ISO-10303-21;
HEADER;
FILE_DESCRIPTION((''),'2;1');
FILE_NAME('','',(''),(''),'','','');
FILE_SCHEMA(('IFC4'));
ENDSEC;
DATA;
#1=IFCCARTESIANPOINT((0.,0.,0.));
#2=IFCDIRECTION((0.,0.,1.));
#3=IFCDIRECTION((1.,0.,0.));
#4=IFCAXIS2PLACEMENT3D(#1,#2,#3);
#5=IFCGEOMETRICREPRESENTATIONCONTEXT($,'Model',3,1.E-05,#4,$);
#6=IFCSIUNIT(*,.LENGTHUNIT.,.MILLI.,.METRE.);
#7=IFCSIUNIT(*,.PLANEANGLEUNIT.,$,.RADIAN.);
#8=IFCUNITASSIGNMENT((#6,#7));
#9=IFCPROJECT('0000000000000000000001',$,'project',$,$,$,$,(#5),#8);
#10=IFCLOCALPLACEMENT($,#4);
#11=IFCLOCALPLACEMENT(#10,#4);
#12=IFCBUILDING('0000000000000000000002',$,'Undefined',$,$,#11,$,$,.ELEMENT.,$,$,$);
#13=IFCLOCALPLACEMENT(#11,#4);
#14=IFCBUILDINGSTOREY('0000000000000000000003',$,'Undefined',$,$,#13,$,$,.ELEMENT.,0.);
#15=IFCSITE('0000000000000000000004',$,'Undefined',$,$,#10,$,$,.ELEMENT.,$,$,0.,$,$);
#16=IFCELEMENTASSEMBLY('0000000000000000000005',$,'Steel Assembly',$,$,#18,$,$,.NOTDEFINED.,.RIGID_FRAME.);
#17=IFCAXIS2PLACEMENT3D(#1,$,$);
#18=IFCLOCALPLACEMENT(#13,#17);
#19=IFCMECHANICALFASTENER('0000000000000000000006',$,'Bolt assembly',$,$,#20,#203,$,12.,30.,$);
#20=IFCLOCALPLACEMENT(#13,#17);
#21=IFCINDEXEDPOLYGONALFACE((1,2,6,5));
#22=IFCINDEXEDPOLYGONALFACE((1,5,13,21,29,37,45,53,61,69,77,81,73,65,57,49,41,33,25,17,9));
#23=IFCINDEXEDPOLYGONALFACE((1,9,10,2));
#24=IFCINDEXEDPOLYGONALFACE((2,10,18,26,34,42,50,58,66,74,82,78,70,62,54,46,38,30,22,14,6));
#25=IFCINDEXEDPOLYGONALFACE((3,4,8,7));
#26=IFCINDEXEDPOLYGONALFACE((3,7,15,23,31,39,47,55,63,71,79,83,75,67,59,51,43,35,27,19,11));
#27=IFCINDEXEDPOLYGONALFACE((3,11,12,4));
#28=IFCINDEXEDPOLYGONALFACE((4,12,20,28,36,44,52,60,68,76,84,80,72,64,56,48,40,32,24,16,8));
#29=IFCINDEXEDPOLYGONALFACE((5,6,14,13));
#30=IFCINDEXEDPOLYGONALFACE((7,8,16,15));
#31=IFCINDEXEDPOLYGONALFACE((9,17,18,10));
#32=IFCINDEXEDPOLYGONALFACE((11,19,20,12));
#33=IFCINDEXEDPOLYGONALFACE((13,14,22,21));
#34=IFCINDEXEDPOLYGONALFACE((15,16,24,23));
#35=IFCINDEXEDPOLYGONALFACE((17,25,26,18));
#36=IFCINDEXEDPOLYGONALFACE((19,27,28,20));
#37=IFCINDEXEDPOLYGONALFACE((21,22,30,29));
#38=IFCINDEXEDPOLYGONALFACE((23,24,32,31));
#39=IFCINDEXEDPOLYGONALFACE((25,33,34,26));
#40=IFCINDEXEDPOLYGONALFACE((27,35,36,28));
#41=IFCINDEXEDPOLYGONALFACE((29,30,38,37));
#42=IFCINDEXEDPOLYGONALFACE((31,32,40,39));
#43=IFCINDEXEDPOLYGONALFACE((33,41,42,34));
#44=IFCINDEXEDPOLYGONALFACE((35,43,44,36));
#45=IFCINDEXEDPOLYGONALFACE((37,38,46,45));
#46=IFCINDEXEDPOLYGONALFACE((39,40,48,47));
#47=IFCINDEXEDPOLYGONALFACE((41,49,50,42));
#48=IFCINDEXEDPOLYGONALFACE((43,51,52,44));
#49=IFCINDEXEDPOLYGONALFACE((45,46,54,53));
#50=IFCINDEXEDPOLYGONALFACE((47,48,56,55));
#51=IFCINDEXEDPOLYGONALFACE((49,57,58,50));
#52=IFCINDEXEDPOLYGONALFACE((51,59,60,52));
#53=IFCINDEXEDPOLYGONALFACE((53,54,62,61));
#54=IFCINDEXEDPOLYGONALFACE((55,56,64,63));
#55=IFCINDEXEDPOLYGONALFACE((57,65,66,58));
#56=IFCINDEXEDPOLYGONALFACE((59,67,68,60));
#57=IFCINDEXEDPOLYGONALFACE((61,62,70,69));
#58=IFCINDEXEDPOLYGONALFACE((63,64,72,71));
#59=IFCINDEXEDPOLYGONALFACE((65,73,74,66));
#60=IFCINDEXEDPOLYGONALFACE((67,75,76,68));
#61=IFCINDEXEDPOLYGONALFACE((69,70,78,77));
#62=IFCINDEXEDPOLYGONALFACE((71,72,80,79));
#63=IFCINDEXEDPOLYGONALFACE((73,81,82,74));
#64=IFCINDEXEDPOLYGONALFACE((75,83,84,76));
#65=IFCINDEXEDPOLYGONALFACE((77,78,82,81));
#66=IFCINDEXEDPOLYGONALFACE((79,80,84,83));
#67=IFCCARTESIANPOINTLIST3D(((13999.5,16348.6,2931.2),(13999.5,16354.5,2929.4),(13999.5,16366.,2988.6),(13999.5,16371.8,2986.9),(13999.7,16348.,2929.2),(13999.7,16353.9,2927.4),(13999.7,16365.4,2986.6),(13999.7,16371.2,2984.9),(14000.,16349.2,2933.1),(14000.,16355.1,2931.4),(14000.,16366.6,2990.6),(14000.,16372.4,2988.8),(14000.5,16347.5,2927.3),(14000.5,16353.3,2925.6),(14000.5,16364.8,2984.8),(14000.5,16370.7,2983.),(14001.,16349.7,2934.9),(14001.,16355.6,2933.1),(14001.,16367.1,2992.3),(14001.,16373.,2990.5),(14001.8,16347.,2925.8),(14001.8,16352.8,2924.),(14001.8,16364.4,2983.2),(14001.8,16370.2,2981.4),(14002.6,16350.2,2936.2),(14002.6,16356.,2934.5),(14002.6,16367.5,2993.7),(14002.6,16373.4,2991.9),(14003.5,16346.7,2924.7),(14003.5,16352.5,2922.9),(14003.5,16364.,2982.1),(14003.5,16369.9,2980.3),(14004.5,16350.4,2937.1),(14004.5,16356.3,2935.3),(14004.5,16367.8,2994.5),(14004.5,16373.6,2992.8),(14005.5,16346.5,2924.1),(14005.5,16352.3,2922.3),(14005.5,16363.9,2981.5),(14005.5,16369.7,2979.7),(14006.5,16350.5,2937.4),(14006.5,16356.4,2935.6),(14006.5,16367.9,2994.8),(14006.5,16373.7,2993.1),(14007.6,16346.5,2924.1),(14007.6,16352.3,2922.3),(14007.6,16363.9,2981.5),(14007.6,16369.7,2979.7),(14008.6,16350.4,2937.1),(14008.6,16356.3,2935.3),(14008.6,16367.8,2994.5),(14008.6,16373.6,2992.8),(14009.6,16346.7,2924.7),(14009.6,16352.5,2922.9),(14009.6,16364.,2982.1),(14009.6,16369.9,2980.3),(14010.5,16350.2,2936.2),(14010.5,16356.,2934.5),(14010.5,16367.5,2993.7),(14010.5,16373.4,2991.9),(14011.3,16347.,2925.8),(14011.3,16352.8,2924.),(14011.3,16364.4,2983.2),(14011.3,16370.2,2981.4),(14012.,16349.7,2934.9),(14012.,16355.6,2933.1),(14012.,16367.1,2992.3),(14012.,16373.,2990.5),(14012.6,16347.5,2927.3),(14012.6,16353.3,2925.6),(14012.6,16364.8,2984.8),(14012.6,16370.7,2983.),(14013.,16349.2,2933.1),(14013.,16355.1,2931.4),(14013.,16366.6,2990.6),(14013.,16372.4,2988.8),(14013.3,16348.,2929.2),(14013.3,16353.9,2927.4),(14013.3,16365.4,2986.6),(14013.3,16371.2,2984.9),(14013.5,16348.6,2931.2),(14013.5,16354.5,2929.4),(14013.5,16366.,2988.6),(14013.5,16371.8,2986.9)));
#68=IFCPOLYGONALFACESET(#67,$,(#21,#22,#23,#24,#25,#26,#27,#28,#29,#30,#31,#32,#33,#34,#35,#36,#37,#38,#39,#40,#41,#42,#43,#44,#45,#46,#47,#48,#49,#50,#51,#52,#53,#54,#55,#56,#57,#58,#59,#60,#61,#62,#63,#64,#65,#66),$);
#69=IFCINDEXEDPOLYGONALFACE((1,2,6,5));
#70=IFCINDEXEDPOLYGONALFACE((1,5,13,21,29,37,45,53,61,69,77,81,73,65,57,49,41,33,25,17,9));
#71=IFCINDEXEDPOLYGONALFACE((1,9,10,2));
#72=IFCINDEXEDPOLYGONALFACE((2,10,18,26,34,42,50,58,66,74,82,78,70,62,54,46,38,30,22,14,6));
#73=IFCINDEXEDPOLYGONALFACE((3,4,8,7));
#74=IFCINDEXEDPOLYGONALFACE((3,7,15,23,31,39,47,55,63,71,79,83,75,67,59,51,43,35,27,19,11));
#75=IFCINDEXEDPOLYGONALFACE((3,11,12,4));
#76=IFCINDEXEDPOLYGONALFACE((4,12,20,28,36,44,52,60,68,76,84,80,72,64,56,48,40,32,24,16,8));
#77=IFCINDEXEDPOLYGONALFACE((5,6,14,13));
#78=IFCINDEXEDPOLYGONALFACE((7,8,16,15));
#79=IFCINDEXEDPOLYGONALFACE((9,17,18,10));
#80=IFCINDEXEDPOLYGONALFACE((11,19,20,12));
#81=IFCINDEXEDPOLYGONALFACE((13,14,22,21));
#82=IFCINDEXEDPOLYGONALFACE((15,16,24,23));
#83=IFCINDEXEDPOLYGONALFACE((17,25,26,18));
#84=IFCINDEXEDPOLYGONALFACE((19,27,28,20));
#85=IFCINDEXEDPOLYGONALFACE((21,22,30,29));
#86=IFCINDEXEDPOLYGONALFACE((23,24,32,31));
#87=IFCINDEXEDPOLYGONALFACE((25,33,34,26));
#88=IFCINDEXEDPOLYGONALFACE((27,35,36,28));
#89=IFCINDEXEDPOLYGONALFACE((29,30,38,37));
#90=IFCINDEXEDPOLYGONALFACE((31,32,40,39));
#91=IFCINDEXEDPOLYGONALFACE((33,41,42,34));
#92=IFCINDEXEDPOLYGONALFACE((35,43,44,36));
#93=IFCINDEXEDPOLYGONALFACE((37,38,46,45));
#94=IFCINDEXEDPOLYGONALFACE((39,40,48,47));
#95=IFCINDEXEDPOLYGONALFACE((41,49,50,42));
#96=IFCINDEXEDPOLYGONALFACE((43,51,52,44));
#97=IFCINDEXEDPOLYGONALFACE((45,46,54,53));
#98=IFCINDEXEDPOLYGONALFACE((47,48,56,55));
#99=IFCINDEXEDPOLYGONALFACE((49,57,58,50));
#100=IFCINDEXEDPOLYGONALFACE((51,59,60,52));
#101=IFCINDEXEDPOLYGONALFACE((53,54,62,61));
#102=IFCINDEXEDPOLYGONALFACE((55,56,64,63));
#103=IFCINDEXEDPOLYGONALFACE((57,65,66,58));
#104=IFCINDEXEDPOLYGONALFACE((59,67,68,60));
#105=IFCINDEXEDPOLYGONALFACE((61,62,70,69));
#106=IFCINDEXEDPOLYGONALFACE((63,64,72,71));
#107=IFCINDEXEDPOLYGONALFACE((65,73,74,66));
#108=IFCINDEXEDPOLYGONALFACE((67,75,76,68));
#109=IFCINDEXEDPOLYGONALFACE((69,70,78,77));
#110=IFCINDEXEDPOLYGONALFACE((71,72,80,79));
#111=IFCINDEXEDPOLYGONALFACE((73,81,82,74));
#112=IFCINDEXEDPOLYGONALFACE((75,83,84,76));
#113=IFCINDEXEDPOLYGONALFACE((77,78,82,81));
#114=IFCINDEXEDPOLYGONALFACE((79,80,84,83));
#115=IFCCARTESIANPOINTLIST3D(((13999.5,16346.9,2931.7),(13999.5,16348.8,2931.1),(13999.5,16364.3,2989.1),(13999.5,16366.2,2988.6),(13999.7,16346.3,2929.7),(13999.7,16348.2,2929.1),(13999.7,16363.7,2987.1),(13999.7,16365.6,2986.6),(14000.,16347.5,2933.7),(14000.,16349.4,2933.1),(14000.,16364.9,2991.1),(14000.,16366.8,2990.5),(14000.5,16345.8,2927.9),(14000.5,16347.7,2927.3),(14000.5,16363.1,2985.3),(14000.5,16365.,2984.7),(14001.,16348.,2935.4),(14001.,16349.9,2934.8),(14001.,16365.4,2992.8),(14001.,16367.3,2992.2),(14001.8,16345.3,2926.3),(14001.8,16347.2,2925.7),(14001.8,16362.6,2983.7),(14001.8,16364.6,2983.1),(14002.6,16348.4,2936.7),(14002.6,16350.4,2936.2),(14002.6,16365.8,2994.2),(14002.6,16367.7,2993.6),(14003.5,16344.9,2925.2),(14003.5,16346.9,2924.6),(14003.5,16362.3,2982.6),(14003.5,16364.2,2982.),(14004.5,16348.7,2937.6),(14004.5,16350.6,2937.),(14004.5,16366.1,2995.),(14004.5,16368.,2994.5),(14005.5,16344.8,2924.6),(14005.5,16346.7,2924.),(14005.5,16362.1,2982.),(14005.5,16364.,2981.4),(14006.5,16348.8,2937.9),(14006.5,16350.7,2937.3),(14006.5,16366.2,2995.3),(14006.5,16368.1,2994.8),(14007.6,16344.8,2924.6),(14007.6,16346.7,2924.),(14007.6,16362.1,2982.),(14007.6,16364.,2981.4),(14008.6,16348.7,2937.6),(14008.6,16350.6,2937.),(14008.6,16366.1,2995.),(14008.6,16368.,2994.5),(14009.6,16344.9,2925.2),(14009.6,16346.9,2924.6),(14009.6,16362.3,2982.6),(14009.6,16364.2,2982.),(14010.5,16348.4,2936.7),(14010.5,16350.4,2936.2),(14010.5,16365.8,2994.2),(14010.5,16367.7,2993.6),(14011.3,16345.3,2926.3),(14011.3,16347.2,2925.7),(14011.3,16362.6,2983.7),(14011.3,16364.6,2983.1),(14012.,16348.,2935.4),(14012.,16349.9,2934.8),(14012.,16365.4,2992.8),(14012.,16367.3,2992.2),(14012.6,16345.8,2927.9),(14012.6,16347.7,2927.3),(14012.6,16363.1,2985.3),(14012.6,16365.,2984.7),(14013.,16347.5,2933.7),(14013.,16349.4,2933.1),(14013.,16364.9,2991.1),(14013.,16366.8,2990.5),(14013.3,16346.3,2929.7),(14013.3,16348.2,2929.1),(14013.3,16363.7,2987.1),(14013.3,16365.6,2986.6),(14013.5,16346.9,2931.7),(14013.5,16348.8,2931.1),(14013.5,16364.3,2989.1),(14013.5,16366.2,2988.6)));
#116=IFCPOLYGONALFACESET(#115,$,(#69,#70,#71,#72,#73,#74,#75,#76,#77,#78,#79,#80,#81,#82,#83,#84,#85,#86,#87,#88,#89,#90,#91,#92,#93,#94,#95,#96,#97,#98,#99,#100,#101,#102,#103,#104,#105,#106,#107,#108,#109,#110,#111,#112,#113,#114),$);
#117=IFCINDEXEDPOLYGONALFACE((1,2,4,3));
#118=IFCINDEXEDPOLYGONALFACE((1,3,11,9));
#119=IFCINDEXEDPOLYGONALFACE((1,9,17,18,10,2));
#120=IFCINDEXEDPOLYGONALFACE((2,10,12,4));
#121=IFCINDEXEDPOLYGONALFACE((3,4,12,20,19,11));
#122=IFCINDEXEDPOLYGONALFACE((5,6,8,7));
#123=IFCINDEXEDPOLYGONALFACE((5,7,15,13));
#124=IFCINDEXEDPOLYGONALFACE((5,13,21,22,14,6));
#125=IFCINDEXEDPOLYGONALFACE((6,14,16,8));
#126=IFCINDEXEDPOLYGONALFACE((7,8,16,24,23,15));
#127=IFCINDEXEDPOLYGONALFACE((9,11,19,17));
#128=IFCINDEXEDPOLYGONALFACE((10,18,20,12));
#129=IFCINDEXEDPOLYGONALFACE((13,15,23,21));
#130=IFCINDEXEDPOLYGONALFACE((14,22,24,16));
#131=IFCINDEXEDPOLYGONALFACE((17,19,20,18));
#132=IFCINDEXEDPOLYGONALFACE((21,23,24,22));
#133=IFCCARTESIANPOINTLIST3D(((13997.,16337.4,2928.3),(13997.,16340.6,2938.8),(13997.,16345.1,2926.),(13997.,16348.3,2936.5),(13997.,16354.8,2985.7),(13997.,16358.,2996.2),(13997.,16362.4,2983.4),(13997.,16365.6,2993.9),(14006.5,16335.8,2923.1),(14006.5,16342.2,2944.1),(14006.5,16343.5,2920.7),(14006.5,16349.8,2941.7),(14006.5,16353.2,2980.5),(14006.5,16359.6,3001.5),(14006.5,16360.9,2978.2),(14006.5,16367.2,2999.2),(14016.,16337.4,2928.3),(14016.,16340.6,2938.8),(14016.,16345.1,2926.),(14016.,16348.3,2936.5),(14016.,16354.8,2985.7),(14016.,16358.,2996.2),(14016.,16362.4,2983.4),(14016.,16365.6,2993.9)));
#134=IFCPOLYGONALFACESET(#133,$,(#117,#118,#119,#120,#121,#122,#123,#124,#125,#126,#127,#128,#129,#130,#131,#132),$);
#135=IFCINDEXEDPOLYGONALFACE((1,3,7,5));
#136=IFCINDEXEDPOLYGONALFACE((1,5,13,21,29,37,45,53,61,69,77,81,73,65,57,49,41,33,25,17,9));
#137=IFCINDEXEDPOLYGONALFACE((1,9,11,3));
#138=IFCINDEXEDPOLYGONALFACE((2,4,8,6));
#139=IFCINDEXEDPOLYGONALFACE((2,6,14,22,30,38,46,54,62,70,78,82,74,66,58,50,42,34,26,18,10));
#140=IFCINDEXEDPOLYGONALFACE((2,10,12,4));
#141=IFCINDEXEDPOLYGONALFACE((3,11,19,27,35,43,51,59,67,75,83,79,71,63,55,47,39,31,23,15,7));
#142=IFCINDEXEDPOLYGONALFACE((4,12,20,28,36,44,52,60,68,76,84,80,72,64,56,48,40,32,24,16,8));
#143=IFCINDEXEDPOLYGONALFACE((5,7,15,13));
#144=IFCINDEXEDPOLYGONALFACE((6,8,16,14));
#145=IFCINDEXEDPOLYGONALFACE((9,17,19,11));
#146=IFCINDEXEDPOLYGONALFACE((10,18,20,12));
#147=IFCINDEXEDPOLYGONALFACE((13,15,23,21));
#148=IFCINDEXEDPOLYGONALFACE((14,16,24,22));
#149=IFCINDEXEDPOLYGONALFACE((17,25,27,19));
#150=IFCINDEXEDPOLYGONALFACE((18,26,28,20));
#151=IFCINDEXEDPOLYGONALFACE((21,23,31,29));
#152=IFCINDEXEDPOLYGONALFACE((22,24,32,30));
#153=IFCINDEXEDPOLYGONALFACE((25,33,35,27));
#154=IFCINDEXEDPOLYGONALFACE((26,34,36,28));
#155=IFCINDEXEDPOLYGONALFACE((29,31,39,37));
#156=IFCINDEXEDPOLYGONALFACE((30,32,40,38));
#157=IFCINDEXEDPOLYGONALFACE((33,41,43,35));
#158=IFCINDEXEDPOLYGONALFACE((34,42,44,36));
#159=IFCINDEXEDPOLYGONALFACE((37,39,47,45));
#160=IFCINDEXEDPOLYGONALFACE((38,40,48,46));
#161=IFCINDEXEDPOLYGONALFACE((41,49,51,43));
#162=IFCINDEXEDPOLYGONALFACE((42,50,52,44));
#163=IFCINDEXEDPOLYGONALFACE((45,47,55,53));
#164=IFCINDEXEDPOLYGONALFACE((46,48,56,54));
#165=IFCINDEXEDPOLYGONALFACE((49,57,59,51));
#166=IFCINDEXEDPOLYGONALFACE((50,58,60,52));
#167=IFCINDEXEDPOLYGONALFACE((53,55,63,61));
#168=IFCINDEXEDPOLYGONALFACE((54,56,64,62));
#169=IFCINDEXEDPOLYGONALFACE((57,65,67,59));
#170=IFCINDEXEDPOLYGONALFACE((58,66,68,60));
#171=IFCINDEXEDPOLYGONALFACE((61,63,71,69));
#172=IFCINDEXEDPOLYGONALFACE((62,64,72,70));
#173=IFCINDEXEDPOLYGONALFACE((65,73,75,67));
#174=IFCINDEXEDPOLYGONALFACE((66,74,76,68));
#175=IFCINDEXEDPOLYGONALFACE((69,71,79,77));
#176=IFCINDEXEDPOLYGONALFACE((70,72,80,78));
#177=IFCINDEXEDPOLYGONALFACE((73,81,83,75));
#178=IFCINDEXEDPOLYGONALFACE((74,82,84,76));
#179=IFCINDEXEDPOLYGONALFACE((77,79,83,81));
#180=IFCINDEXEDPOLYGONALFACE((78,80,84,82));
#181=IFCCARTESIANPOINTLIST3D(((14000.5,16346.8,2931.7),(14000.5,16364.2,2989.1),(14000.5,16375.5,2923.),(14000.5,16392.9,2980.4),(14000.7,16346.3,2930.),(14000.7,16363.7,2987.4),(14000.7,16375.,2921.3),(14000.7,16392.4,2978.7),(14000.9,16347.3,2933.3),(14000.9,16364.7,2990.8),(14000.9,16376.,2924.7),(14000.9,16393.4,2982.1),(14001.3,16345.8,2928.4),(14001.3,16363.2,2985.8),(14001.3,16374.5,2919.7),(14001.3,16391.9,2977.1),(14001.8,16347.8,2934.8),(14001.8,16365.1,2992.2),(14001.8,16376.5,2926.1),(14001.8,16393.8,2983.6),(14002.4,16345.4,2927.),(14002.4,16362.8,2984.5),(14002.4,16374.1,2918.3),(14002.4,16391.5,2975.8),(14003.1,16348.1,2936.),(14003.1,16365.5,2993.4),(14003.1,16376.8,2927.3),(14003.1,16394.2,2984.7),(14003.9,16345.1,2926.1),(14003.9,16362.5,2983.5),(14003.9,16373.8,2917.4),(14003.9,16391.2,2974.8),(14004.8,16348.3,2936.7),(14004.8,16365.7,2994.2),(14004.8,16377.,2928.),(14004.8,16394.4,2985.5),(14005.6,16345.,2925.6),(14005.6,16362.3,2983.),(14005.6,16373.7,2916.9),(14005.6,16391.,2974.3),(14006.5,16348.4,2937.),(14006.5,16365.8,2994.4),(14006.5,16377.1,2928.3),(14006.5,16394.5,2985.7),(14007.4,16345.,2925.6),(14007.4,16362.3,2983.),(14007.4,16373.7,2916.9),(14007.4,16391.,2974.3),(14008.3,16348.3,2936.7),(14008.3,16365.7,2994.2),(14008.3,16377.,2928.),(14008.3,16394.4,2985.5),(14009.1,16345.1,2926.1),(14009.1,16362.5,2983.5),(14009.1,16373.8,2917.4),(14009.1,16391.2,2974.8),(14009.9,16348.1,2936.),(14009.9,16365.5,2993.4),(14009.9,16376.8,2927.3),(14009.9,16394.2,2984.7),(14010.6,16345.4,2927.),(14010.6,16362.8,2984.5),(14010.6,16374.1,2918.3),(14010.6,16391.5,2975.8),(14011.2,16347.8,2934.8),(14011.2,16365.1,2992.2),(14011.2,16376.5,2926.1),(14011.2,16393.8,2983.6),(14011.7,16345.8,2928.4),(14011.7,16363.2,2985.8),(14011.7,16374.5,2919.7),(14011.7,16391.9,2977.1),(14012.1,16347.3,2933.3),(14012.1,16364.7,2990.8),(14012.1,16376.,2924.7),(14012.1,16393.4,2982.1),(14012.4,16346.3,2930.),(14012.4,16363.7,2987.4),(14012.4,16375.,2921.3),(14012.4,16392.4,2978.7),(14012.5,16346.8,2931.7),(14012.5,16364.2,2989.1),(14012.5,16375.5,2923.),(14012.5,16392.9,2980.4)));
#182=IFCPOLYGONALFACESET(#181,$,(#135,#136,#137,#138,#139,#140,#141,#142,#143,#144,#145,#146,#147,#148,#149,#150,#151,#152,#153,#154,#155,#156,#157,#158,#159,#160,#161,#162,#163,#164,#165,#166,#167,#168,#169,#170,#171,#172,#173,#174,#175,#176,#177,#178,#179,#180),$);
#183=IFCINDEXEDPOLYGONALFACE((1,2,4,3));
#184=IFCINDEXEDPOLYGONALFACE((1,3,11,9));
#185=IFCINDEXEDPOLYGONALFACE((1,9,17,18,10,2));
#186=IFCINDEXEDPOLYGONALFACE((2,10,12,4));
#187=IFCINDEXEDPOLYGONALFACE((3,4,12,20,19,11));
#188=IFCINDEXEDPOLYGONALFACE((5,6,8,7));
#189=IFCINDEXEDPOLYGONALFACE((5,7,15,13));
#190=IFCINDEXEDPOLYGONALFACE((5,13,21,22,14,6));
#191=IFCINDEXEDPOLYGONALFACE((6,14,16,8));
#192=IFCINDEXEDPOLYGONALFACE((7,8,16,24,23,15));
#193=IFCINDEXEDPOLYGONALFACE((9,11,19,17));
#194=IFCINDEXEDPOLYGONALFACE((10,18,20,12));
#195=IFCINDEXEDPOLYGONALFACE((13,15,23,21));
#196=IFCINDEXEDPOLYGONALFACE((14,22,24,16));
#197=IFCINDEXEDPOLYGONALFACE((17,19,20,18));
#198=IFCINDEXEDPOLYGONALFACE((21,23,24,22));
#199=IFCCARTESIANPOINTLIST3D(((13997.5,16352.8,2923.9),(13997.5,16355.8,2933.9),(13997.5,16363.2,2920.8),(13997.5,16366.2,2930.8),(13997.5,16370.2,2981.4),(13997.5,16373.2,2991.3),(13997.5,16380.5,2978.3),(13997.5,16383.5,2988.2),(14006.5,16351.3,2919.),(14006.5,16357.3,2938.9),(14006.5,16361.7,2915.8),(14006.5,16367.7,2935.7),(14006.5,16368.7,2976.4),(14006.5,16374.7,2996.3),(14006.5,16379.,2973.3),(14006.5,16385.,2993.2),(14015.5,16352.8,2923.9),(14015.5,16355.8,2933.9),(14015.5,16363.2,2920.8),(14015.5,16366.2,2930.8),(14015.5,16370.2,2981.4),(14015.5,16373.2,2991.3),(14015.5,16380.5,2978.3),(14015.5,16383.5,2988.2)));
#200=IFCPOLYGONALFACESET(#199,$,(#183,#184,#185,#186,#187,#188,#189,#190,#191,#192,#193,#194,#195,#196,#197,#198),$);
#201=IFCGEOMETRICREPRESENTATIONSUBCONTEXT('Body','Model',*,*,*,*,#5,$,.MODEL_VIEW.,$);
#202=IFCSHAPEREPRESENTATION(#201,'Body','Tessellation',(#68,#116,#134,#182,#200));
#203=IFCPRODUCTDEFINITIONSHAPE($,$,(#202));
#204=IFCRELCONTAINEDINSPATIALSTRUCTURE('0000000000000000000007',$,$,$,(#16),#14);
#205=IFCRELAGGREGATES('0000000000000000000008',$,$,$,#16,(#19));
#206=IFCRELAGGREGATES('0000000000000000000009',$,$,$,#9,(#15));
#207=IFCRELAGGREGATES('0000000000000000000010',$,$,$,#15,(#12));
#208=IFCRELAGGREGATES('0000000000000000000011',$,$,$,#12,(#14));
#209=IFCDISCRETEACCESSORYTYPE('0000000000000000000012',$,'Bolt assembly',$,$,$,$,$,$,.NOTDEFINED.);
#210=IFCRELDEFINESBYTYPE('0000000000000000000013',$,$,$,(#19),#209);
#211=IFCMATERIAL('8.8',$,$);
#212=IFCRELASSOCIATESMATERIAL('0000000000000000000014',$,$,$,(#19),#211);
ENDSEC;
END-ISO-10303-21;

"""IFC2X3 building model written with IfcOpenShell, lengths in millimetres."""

from ifc_helpers import new_model, si_unit, frame, origin_with_axes, origin_2d_with_axis, place, context, subcontext, project, spatial, polyline, circle, outline, extrude, source, transform, mapped, material, type_object, element, aggregate, save


model = new_model("IFC2X3")

# Units and contexts
model_context = context("Model", 3, precision=1e-05, world=origin_with_axes())
body_context = subcontext(model_context, "Body", "Model", "MODEL_VIEW")
ifc_project = project(units=[si_unit("LENGTHUNIT", "METRE", prefix="MILLI"), si_unit("PLANEANGLEUNIT", "RADIAN")], contexts=[model_context])

# Site, building, storey
site_placement = place(None, origin_with_axes())
site = spatial("IfcSite", under=ifc_project, at=site_placement, Name="Undefined", CompositionType="ELEMENT", RefElevation=0.0)
building_placement = place(site_placement, origin_with_axes())
building = spatial("IfcBuilding", under=site, at=building_placement, Name="Undefined", CompositionType="ELEMENT")
storey_placement = place(building_placement, origin_with_axes())
storey = spatial("IfcBuildingStorey", under=building, at=storey_placement, Name="Undefined", CompositionType="ELEMENT", Elevation=0.0)

# Element assembly
assembly_1_placement = place(storey_placement, origin_with_axes())
assembly_1 = element("IfcElementAssembly", 1, at=assembly_1_placement, inside=storey, Name="Steel Assembly", AssemblyPlace="NOTDEFINED", PredefinedType="RIGID_FRAME")

# Shared definitions
discrete_accessory_type_1 = type_object("IfcDiscreteAccessoryType", Name="Bolt assembly")

# Shared definitions
ifc_material_1 = material(Name="8.8")

# Mechanical fastener
shared_shape_1 = source(origin_with_axes(), body_context, "Body", "SweptSolid", [
    extrude(circle(Radius=7.0, at=origin_2d_with_axis()), frame((0.0, -3.1, 0.0), z_axis=(0.0, 1.0, 0.0), x_axis=(1.0, 0.0, 0.0)), (0.0, 0.0, 1.0), 6.1),
    extrude(circle(Radius=7.0, at=origin_2d_with_axis()), frame((0.0, -4.9, 0.0), z_axis=(0.0, 1.0, 0.0), x_axis=(1.0, 0.0, 0.0)), (0.0, 0.0, 1.0), 2.0),
    extrude(outline(polyline([(11.0, 0.0), (5.5, 9.5), (-5.5, 9.5), (-11.0, 0.0), (-5.5, -9.5), (5.5, -9.5), (11.0, 0.0)])), frame((0.0, -13.0, 0.0), z_axis=(0.0, 1.0, 0.0), x_axis=(1.0, 0.0, 0.0)), (0.0, 0.0, 1.0), 8.0),
    extrude(circle(Radius=6.0, at=origin_2d_with_axis()), frame((0.0, -5.0, 0.0), z_axis=(0.0, 1.0, 0.0), x_axis=(1.0, 0.0, 0.0)), (0.0, 0.0, 1.0), 30.0),
    extrude(outline(polyline([(10.4, 0.0), (5.2, 9.0), (-5.2, 9.0), (-10.4, 0.0), (-5.2, -9.0), (5.2, -9.0), (10.4, 0.0)])), frame((0.0, 3.0, 0.0), z_axis=(0.0, 1.0, 0.0), x_axis=(1.0, 0.0, 0.0)), (0.0, 0.0, 1.0), 10.8),
])
mechanical_fastener_1_placement = place(assembly_1_placement, frame((14051.5, 16338.4, 2886.7), z_axis=(-1.0, 0.0, 0.0), x_axis=(0.0, 0.289497, 0.957179)))
mechanical_fastener_1 = element("IfcMechanicalFastener", 2, at=mechanical_fastener_1_placement, type_object=discrete_accessory_type_1, material=ifc_material_1, Name="Bolt assembly", NominalDiameter=12.0, NominalLength=30.0, context=body_context, shape_type="MappedRepresentation", body=[
    mapped(shared_shape_1, transform((45.0, 0.0, 45.0))),
    mapped(shared_shape_1, transform((105.0, 0.0, 45.0))),
])
aggregate(assembly_1, [mechanical_fastener_1])

save(model, "model.ifc")
